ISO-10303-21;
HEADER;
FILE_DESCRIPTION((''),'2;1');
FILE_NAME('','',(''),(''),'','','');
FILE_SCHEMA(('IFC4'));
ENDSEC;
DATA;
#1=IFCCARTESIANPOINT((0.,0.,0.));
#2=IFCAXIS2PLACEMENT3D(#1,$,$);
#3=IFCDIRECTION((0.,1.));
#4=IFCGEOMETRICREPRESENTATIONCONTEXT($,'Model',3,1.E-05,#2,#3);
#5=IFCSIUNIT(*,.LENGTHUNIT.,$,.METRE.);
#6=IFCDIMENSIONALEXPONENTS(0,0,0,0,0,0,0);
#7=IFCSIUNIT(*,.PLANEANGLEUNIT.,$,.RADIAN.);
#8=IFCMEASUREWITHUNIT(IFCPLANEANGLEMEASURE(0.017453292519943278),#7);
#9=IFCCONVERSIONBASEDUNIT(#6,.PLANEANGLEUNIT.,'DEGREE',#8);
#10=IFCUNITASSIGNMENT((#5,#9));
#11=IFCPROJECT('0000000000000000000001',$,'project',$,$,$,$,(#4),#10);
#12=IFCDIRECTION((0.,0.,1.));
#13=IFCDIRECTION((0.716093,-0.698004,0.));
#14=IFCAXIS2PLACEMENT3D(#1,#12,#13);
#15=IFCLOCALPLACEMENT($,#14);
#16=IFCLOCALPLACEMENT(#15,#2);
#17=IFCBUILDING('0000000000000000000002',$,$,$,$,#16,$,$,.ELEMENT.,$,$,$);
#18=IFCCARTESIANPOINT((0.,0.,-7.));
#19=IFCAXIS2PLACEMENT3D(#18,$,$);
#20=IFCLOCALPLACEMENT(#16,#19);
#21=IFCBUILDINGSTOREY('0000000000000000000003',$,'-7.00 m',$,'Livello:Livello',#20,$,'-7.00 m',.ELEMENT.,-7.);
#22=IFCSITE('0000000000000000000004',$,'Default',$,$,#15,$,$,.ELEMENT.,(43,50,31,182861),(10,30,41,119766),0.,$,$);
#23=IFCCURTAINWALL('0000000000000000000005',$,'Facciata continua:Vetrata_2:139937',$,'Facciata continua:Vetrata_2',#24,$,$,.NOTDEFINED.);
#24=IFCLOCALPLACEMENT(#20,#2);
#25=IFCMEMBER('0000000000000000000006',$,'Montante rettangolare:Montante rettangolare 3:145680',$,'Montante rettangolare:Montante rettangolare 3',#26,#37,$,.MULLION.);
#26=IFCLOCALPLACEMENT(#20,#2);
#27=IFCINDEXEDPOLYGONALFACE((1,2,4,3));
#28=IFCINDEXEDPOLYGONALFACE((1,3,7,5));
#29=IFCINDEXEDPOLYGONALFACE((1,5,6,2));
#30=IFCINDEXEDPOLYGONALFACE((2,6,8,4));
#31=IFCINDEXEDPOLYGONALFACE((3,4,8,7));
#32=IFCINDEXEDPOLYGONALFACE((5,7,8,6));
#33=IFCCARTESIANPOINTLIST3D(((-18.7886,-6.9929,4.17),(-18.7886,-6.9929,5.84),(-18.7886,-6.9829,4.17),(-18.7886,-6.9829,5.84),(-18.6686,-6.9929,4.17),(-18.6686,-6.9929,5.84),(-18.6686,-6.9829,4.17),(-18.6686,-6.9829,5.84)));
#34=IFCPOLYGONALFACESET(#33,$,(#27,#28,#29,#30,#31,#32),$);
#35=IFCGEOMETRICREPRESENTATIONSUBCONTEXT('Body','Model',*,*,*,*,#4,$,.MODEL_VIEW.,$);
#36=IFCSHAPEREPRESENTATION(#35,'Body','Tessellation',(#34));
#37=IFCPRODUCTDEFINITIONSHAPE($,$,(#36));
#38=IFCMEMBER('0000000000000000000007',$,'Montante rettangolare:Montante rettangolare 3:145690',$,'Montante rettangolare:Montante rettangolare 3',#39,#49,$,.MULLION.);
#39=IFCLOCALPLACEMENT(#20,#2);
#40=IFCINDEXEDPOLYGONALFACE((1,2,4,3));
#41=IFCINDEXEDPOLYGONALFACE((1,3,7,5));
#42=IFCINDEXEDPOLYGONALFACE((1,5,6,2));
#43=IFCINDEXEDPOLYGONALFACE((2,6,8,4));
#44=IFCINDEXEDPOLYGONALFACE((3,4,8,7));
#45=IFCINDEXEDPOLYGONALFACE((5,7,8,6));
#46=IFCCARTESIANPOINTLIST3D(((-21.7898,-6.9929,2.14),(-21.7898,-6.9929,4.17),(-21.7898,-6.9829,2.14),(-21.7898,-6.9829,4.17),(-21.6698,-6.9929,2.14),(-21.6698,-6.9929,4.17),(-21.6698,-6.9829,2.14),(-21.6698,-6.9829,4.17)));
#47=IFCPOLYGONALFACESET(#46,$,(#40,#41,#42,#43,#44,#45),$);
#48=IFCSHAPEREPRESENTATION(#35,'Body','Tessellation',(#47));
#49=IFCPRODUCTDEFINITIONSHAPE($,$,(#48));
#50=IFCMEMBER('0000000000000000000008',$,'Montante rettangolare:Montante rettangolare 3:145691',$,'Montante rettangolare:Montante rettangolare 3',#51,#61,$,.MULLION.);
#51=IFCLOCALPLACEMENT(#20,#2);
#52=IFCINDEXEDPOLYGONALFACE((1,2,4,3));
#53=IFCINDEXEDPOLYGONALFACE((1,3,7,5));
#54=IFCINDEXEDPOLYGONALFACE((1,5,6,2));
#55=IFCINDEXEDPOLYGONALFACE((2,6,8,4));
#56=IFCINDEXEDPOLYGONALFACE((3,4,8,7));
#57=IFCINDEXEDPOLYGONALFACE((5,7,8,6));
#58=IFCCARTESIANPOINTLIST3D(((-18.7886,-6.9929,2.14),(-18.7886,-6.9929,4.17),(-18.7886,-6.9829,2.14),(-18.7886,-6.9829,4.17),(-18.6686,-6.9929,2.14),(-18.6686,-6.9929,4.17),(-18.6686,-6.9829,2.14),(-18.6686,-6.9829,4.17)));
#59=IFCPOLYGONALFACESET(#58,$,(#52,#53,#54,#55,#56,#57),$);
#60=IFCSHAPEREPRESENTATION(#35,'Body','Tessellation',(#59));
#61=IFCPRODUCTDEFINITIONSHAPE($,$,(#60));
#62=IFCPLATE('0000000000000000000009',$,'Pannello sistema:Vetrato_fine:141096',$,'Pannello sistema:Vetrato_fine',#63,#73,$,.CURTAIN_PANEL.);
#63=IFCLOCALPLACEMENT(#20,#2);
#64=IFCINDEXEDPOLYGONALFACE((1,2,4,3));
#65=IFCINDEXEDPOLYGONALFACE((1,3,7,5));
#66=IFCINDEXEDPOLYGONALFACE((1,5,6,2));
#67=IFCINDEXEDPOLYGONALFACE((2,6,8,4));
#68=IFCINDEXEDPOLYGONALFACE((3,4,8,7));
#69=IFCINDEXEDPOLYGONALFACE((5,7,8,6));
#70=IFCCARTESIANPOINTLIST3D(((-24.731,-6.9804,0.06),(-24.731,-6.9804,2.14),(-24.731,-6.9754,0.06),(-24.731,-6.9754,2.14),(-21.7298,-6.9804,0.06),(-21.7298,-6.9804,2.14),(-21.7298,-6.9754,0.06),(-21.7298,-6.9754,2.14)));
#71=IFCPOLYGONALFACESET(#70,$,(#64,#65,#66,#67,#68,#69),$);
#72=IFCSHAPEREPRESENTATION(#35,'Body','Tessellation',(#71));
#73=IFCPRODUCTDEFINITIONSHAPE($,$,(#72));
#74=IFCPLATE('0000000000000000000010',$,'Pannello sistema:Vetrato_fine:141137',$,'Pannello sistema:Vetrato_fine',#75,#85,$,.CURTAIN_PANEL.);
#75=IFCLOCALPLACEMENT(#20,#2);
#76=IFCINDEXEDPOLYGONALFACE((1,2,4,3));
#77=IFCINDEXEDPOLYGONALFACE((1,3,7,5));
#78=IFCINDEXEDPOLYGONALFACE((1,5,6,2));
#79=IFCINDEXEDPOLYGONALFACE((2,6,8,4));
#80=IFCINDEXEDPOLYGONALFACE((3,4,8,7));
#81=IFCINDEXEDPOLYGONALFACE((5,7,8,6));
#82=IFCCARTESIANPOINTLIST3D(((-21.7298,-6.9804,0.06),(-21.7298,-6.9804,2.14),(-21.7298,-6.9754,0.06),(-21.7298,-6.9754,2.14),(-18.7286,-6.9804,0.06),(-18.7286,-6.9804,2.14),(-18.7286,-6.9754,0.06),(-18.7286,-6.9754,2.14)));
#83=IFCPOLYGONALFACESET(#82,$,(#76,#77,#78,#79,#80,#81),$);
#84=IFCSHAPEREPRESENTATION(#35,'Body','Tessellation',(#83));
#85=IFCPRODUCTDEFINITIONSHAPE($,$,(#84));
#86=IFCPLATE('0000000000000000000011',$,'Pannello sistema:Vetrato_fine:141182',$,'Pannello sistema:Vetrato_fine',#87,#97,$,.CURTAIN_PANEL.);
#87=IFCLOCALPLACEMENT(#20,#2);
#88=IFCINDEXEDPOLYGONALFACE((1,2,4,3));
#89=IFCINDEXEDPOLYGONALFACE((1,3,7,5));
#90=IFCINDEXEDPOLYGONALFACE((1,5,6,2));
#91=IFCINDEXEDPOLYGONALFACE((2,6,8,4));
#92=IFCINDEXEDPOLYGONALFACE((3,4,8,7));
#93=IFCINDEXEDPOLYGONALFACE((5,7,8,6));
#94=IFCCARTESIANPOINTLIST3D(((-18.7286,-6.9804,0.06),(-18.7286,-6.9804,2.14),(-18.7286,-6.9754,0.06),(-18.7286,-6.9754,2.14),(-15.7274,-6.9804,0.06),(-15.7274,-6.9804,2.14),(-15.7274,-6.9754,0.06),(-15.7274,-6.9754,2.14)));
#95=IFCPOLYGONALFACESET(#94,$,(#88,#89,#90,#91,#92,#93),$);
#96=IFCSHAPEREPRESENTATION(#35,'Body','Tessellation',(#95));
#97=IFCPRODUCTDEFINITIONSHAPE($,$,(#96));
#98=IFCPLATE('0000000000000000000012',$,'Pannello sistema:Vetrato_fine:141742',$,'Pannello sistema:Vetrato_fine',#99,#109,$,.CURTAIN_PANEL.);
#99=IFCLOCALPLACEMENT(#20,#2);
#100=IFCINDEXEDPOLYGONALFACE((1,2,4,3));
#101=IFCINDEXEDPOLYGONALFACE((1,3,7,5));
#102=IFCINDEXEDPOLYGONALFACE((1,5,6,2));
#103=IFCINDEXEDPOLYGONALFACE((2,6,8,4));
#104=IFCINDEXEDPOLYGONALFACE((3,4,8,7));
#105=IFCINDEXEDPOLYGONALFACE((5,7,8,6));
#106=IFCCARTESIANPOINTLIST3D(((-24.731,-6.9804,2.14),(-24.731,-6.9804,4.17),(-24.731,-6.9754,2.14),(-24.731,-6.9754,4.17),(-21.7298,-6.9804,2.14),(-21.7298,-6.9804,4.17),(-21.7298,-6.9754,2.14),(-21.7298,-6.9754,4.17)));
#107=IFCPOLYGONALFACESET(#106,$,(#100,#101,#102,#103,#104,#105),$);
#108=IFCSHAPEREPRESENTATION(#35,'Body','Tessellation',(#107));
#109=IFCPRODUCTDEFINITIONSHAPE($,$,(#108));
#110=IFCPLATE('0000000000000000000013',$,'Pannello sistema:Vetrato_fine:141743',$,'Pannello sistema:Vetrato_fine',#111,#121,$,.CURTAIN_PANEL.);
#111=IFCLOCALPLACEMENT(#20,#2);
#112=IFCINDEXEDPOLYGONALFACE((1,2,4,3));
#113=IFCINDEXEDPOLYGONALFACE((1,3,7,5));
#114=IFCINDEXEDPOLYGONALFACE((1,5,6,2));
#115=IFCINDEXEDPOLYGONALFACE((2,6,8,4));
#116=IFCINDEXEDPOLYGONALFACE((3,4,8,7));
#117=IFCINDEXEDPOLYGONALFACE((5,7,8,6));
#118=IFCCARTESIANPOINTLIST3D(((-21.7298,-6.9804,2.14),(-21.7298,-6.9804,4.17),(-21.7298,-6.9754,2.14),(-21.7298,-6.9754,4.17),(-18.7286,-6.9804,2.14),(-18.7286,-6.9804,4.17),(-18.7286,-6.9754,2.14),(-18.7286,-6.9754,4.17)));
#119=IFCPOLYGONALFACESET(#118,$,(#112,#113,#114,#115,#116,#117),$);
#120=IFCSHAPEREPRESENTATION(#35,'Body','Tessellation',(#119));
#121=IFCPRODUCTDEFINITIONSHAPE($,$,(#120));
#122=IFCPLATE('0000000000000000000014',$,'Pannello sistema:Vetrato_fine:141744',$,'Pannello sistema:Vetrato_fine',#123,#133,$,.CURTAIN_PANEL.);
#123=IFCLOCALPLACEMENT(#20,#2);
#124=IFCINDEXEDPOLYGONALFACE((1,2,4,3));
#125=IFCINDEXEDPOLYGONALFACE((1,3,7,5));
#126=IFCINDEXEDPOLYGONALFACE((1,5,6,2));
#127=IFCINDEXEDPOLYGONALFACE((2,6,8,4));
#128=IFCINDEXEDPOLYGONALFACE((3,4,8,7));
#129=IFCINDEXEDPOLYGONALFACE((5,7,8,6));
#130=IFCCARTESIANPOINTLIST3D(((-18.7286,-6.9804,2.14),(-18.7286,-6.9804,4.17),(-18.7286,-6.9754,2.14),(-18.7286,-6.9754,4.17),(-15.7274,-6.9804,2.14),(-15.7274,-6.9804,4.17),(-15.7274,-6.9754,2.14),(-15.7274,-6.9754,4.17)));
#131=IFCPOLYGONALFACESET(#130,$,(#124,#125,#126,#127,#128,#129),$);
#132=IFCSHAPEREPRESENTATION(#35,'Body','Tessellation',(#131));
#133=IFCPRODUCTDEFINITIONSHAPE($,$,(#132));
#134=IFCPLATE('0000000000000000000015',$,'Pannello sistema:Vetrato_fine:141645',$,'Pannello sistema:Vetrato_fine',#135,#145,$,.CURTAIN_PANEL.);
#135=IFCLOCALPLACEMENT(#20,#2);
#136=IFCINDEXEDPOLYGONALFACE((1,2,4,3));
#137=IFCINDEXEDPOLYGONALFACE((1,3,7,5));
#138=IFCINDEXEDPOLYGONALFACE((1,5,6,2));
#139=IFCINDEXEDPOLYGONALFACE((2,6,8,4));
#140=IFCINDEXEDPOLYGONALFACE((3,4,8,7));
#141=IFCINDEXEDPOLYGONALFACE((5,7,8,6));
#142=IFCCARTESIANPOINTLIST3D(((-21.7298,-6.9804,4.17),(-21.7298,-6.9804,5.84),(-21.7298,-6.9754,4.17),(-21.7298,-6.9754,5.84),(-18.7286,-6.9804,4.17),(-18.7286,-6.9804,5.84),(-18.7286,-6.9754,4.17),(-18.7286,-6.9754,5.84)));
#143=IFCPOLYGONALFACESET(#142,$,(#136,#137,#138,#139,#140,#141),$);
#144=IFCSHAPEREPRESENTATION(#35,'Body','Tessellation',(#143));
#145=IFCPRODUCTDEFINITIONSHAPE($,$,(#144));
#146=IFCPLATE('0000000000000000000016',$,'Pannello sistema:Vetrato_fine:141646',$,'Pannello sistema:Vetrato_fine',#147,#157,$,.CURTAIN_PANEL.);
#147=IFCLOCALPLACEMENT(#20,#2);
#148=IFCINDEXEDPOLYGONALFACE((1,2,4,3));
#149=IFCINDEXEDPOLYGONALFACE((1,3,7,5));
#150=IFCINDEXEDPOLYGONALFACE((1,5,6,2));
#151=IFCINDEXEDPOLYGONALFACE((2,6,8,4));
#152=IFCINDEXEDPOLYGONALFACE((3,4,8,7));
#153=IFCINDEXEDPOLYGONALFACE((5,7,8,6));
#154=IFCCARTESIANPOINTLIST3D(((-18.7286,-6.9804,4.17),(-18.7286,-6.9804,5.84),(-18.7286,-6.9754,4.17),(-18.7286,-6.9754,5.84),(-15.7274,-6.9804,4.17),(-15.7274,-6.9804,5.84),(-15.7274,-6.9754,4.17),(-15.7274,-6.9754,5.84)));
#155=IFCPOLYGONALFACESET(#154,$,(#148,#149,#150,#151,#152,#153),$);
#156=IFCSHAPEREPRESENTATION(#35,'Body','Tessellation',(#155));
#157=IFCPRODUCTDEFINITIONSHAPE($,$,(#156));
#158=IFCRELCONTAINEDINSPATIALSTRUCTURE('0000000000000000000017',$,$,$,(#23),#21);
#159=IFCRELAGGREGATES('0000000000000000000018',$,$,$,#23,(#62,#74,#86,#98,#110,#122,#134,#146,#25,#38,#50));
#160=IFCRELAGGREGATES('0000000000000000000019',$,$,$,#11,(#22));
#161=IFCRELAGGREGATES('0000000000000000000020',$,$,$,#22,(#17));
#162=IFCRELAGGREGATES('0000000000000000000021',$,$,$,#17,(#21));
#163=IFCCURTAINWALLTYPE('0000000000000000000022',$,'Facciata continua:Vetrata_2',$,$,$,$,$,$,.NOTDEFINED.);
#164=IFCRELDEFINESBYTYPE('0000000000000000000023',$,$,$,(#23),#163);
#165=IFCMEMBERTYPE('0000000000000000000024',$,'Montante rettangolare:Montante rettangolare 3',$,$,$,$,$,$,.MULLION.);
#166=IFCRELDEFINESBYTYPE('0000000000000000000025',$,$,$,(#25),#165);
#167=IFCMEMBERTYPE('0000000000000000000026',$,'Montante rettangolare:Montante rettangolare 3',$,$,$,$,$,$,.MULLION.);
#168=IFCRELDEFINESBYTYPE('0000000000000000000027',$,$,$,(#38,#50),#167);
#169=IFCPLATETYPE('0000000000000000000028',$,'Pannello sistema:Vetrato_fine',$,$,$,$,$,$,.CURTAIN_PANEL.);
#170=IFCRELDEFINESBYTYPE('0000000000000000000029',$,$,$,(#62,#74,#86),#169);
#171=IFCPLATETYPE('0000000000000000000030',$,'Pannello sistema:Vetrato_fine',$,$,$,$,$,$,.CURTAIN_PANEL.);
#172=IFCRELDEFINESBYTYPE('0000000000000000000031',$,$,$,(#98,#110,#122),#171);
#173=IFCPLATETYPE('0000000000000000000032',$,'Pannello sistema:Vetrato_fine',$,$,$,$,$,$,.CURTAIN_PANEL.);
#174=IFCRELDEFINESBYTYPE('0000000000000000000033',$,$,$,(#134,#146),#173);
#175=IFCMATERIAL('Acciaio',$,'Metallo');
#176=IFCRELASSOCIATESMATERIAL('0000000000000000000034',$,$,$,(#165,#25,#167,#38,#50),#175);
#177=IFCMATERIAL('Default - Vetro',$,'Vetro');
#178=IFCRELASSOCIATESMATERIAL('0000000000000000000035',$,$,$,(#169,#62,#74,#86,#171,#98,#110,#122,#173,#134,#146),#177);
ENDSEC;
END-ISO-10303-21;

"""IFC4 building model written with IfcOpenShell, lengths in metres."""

from ifc_helpers import new_model, entity, si_unit, converted_unit, direction, frame, origin, place, context, subcontext, project, spatial, indexed_curve, outline, extrude, source, transform, mapped, material, type_object, type_shapes, element, aggregate, save


model = new_model("IFC4")

# Units and contexts
model_context = context("Model", 3, precision=1e-05, world=origin(), true_north=direction((0.0, 1.0)))
body_context = subcontext(model_context, "Body", "Model", "MODEL_VIEW")
ifc_project = project(units=[si_unit("LENGTHUNIT", "METRE"), converted_unit("PLANEANGLEUNIT", "DEGREE", entity("IfcPlaneAngleMeasure", 0.017453292519943278), si_unit("PLANEANGLEUNIT", "RADIAN"), dimensions=[0, 0, 0, 0, 0, 0, 0])], contexts=[model_context])

# Site, building, storey
site_placement = place(None, frame((0.0, 0.0, 0.0), z_axis=(0.0, 0.0, 1.0), x_axis=(0.716093, -0.698004, 0.0)))
site = spatial("IfcSite", under=ifc_project, at=site_placement, Name="Default", CompositionType="ELEMENT", RefLatitude=(43, 50, 31, 182861), RefLongitude=(10, 30, 41, 119766), RefElevation=0.0)
building_placement = place(site_placement, origin())
building = spatial("IfcBuilding", under=site, at=building_placement, CompositionType="ELEMENT")
storey_placement = place(building_placement, frame((0.0, 0.0, -7.0)))
storey = spatial("IfcBuildingStorey", under=building, at=storey_placement, Name="-7.00 m", ObjectType="Livello:Livello", LongName="-7.00 m", CompositionType="ELEMENT", Elevation=-7.0)

# Curtain wall, members, plates
curtain_wall_type = type_object("IfcCurtainWallType", Name="Facciata continua:Vetrata_2", PredefinedType="NOTDEFINED")
curtain_wall_placement = place(storey_placement, frame((0.0, 0.0, 7.0)))
curtain_wall = element("IfcCurtainWall", 1, at=curtain_wall_placement, inside=storey, type_object=curtain_wall_type, Name="Facciata continua:Vetrata_2:139937", ObjectType="Facciata continua:Vetrata_2", PredefinedType="NOTDEFINED")
ifc_material_1 = material(Name="Acciaio", Category="Metallo")
member_type_1 = type_object("IfcMemberType", Name="Montante rettangolare:Montante rettangolare 3", PredefinedType="MULLION", material=ifc_material_1)
shared_shape_1 = source(origin(), body_context, "Body", "SweptSolid", [
    extrude(outline(indexed_curve([(-0.06, -0.005), (0.06, -0.005), (0.06, 0.005), (-0.06, 0.005), (-0.06, -0.005)], self_intersect=False)), frame((0.0, 0.01, -1.67), z_axis=(0.0, 0.0, 1.0), x_axis=(-1.0, 0.0, 0.0)), (0.0, 0.0, 1.0), 1.67),
])
type_shapes(member_type_1, [shared_shape_1])
member_1_placement = place(curtain_wall_placement, frame((-18.7286, -6.9779, -2.83), z_axis=(0.0, 0.0, -1.0), x_axis=(1.0, 0.0, 0.0)))
member_1 = element("IfcMember", 2, at=member_1_placement, type_object=member_type_1, material=ifc_material_1, Name="Montante rettangolare:Montante rettangolare 3:145680", ObjectType="Montante rettangolare:Montante rettangolare 3", PredefinedType="MULLION", context=body_context, shape_type="MappedRepresentation", body=[
    mapped(shared_shape_1, transform((0.0, 0.0, 0.0), scale=1.0)),
])
member_type_2 = type_object("IfcMemberType", Name="Montante rettangolare:Montante rettangolare 3", PredefinedType="MULLION", material=ifc_material_1)
shared_shape_2 = source(origin(), body_context, "Body", "SweptSolid", [
    extrude(outline(indexed_curve([(-0.06, -0.005), (0.06, -0.005), (0.06, 0.005), (-0.06, 0.005), (-0.06, -0.005)], self_intersect=False)), frame((0.0, 0.01, -2.03), z_axis=(0.0, 0.0, 1.0), x_axis=(-1.0, 0.0, 0.0)), (0.0, 0.0, 1.0), 2.03),
])
type_shapes(member_type_2, [shared_shape_2])
member_2_placement = place(curtain_wall_placement, frame((-21.7298, -6.9779, -4.86), z_axis=(0.0, 0.0, -1.0), x_axis=(1.0, 0.0, 0.0)))
member_2 = element("IfcMember", 3, at=member_2_placement, type_object=member_type_2, material=ifc_material_1, Name="Montante rettangolare:Montante rettangolare 3:145690", ObjectType="Montante rettangolare:Montante rettangolare 3", PredefinedType="MULLION", context=body_context, shape_type="MappedRepresentation", body=[
    mapped(shared_shape_2, transform((0.0, 0.0, 0.0), scale=1.0)),
])
member_3_placement = place(curtain_wall_placement, frame((-18.7286, -6.9779, -4.86), z_axis=(0.0, 0.0, -1.0), x_axis=(1.0, 0.0, 0.0)))
member_3 = element("IfcMember", 4, at=member_3_placement, type_object=member_type_2, material=ifc_material_1, Name="Montante rettangolare:Montante rettangolare 3:145691", ObjectType="Montante rettangolare:Montante rettangolare 3", PredefinedType="MULLION", context=body_context, shape_type="MappedRepresentation", body=[
    mapped(shared_shape_2, transform((0.0, 0.0, 0.0), scale=1.0)),
])
ifc_material_2 = material(Name="Default - Vetro", Category="Vetro")
plate_type_1 = type_object("IfcPlateType", Name="Pannello sistema:Vetrato_fine", PredefinedType="CURTAIN_PANEL", material=ifc_material_2)
shared_shape_3 = source(origin(), body_context, "Body", "SweptSolid", [
    extrude(outline(indexed_curve([(-0.0025, -1.5006), (0.0025, -1.5006), (0.0025, 1.5006), (-0.0025, 1.5006), (-0.0025, -1.5006)], self_intersect=False)), frame((0.0, 0.0, 0.0), z_axis=(0.0, 0.0, 1.0), x_axis=(0.0, 1.0, 0.0)), (0.0, 0.0, 1.0), 2.08),
])
type_shapes(plate_type_1, [shared_shape_3])
plate_1_placement = place(curtain_wall_placement, frame((-23.2304, -6.9779, -6.94)))
plate_1 = element("IfcPlate", 5, at=plate_1_placement, type_object=plate_type_1, material=ifc_material_2, Name="Pannello sistema:Vetrato_fine:141096", ObjectType="Pannello sistema:Vetrato_fine", PredefinedType="CURTAIN_PANEL", context=body_context, shape_type="MappedRepresentation", body=[
    mapped(shared_shape_3, transform((0.0, 0.0, 0.0), scale=1.0)),
])
plate_2_placement = place(curtain_wall_placement, frame((-20.2292, -6.9779, -6.94)))
plate_2 = element("IfcPlate", 6, at=plate_2_placement, type_object=plate_type_1, material=ifc_material_2, Name="Pannello sistema:Vetrato_fine:141137", ObjectType="Pannello sistema:Vetrato_fine", PredefinedType="CURTAIN_PANEL", context=body_context, shape_type="MappedRepresentation", body=[
    mapped(shared_shape_3, transform((0.0, 0.0, 0.0), scale=1.0)),
])
plate_3_placement = place(curtain_wall_placement, frame((-17.228, -6.9779, -6.94)))
plate_3 = element("IfcPlate", 7, at=plate_3_placement, type_object=plate_type_1, material=ifc_material_2, Name="Pannello sistema:Vetrato_fine:141182", ObjectType="Pannello sistema:Vetrato_fine", PredefinedType="CURTAIN_PANEL", context=body_context, shape_type="MappedRepresentation", body=[
    mapped(shared_shape_3, transform((0.0, 0.0, 0.0), scale=1.0)),
])
plate_type_2 = type_object("IfcPlateType", Name="Pannello sistema:Vetrato_fine", PredefinedType="CURTAIN_PANEL", material=ifc_material_2)
shared_shape_4 = source(origin(), body_context, "Body", "SweptSolid", [
    extrude(outline(indexed_curve([(-0.0025, -1.5006), (0.0025, -1.5006), (0.0025, 1.5006), (-0.0025, 1.5006), (-0.0025, -1.5006)], self_intersect=False)), frame((0.0, 0.0, 0.0), z_axis=(0.0, 0.0, 1.0), x_axis=(0.0, 1.0, 0.0)), (0.0, 0.0, 1.0), 2.03),
])
type_shapes(plate_type_2, [shared_shape_4])
plate_4_placement = place(curtain_wall_placement, frame((-23.2304, -6.9779, -4.86)))
plate_4 = element("IfcPlate", 8, at=plate_4_placement, type_object=plate_type_2, material=ifc_material_2, Name="Pannello sistema:Vetrato_fine:141742", ObjectType="Pannello sistema:Vetrato_fine", PredefinedType="CURTAIN_PANEL", context=body_context, shape_type="MappedRepresentation", body=[
    mapped(shared_shape_4, transform((0.0, 0.0, 0.0), scale=1.0)),
])
plate_5_placement = place(curtain_wall_placement, frame((-20.2292, -6.9779, -4.86)))
plate_5 = element("IfcPlate", 9, at=plate_5_placement, type_object=plate_type_2, material=ifc_material_2, Name="Pannello sistema:Vetrato_fine:141743", ObjectType="Pannello sistema:Vetrato_fine", PredefinedType="CURTAIN_PANEL", context=body_context, shape_type="MappedRepresentation", body=[
    mapped(shared_shape_4, transform((0.0, 0.0, 0.0), scale=1.0)),
])
plate_6_placement = place(curtain_wall_placement, frame((-17.228, -6.9779, -4.86)))
plate_6 = element("IfcPlate", 10, at=plate_6_placement, type_object=plate_type_2, material=ifc_material_2, Name="Pannello sistema:Vetrato_fine:141744", ObjectType="Pannello sistema:Vetrato_fine", PredefinedType="CURTAIN_PANEL", context=body_context, shape_type="MappedRepresentation", body=[
    mapped(shared_shape_4, transform((0.0, 0.0, 0.0), scale=1.0)),
])
plate_type_3 = type_object("IfcPlateType", Name="Pannello sistema:Vetrato_fine", PredefinedType="CURTAIN_PANEL", material=ifc_material_2)
shared_shape_5 = source(origin(), body_context, "Body", "SweptSolid", [
    extrude(outline(indexed_curve([(-0.0025, -1.5006), (0.0025, -1.5006), (0.0025, 1.5006), (-0.0025, 1.5006), (-0.0025, -1.5006)], self_intersect=False)), frame((0.0, 0.0, 0.0), z_axis=(0.0, 0.0, 1.0), x_axis=(0.0, 1.0, 0.0)), (0.0, 0.0, 1.0), 1.67),
])
type_shapes(plate_type_3, [shared_shape_5])
plate_7_placement = place(curtain_wall_placement, frame((-20.2292, -6.9779, -2.83)))
plate_7 = element("IfcPlate", 11, at=plate_7_placement, type_object=plate_type_3, material=ifc_material_2, Name="Pannello sistema:Vetrato_fine:141645", ObjectType="Pannello sistema:Vetrato_fine", PredefinedType="CURTAIN_PANEL", context=body_context, shape_type="MappedRepresentation", body=[
    mapped(shared_shape_5, transform((0.0, 0.0, 0.0), scale=1.0)),
])
plate_8_placement = place(curtain_wall_placement, frame((-17.228, -6.9779, -2.83)))
plate_8 = element("IfcPlate", 12, at=plate_8_placement, type_object=plate_type_3, material=ifc_material_2, Name="Pannello sistema:Vetrato_fine:141646", ObjectType="Pannello sistema:Vetrato_fine", PredefinedType="CURTAIN_PANEL", context=body_context, shape_type="MappedRepresentation", body=[
    mapped(shared_shape_5, transform((0.0, 0.0, 0.0), scale=1.0)),
])
aggregate(curtain_wall, [plate_1, plate_2, plate_3, plate_4, plate_5, plate_6, plate_7, plate_8, member_1, member_2, member_3])

save(model, "model.ifc")
